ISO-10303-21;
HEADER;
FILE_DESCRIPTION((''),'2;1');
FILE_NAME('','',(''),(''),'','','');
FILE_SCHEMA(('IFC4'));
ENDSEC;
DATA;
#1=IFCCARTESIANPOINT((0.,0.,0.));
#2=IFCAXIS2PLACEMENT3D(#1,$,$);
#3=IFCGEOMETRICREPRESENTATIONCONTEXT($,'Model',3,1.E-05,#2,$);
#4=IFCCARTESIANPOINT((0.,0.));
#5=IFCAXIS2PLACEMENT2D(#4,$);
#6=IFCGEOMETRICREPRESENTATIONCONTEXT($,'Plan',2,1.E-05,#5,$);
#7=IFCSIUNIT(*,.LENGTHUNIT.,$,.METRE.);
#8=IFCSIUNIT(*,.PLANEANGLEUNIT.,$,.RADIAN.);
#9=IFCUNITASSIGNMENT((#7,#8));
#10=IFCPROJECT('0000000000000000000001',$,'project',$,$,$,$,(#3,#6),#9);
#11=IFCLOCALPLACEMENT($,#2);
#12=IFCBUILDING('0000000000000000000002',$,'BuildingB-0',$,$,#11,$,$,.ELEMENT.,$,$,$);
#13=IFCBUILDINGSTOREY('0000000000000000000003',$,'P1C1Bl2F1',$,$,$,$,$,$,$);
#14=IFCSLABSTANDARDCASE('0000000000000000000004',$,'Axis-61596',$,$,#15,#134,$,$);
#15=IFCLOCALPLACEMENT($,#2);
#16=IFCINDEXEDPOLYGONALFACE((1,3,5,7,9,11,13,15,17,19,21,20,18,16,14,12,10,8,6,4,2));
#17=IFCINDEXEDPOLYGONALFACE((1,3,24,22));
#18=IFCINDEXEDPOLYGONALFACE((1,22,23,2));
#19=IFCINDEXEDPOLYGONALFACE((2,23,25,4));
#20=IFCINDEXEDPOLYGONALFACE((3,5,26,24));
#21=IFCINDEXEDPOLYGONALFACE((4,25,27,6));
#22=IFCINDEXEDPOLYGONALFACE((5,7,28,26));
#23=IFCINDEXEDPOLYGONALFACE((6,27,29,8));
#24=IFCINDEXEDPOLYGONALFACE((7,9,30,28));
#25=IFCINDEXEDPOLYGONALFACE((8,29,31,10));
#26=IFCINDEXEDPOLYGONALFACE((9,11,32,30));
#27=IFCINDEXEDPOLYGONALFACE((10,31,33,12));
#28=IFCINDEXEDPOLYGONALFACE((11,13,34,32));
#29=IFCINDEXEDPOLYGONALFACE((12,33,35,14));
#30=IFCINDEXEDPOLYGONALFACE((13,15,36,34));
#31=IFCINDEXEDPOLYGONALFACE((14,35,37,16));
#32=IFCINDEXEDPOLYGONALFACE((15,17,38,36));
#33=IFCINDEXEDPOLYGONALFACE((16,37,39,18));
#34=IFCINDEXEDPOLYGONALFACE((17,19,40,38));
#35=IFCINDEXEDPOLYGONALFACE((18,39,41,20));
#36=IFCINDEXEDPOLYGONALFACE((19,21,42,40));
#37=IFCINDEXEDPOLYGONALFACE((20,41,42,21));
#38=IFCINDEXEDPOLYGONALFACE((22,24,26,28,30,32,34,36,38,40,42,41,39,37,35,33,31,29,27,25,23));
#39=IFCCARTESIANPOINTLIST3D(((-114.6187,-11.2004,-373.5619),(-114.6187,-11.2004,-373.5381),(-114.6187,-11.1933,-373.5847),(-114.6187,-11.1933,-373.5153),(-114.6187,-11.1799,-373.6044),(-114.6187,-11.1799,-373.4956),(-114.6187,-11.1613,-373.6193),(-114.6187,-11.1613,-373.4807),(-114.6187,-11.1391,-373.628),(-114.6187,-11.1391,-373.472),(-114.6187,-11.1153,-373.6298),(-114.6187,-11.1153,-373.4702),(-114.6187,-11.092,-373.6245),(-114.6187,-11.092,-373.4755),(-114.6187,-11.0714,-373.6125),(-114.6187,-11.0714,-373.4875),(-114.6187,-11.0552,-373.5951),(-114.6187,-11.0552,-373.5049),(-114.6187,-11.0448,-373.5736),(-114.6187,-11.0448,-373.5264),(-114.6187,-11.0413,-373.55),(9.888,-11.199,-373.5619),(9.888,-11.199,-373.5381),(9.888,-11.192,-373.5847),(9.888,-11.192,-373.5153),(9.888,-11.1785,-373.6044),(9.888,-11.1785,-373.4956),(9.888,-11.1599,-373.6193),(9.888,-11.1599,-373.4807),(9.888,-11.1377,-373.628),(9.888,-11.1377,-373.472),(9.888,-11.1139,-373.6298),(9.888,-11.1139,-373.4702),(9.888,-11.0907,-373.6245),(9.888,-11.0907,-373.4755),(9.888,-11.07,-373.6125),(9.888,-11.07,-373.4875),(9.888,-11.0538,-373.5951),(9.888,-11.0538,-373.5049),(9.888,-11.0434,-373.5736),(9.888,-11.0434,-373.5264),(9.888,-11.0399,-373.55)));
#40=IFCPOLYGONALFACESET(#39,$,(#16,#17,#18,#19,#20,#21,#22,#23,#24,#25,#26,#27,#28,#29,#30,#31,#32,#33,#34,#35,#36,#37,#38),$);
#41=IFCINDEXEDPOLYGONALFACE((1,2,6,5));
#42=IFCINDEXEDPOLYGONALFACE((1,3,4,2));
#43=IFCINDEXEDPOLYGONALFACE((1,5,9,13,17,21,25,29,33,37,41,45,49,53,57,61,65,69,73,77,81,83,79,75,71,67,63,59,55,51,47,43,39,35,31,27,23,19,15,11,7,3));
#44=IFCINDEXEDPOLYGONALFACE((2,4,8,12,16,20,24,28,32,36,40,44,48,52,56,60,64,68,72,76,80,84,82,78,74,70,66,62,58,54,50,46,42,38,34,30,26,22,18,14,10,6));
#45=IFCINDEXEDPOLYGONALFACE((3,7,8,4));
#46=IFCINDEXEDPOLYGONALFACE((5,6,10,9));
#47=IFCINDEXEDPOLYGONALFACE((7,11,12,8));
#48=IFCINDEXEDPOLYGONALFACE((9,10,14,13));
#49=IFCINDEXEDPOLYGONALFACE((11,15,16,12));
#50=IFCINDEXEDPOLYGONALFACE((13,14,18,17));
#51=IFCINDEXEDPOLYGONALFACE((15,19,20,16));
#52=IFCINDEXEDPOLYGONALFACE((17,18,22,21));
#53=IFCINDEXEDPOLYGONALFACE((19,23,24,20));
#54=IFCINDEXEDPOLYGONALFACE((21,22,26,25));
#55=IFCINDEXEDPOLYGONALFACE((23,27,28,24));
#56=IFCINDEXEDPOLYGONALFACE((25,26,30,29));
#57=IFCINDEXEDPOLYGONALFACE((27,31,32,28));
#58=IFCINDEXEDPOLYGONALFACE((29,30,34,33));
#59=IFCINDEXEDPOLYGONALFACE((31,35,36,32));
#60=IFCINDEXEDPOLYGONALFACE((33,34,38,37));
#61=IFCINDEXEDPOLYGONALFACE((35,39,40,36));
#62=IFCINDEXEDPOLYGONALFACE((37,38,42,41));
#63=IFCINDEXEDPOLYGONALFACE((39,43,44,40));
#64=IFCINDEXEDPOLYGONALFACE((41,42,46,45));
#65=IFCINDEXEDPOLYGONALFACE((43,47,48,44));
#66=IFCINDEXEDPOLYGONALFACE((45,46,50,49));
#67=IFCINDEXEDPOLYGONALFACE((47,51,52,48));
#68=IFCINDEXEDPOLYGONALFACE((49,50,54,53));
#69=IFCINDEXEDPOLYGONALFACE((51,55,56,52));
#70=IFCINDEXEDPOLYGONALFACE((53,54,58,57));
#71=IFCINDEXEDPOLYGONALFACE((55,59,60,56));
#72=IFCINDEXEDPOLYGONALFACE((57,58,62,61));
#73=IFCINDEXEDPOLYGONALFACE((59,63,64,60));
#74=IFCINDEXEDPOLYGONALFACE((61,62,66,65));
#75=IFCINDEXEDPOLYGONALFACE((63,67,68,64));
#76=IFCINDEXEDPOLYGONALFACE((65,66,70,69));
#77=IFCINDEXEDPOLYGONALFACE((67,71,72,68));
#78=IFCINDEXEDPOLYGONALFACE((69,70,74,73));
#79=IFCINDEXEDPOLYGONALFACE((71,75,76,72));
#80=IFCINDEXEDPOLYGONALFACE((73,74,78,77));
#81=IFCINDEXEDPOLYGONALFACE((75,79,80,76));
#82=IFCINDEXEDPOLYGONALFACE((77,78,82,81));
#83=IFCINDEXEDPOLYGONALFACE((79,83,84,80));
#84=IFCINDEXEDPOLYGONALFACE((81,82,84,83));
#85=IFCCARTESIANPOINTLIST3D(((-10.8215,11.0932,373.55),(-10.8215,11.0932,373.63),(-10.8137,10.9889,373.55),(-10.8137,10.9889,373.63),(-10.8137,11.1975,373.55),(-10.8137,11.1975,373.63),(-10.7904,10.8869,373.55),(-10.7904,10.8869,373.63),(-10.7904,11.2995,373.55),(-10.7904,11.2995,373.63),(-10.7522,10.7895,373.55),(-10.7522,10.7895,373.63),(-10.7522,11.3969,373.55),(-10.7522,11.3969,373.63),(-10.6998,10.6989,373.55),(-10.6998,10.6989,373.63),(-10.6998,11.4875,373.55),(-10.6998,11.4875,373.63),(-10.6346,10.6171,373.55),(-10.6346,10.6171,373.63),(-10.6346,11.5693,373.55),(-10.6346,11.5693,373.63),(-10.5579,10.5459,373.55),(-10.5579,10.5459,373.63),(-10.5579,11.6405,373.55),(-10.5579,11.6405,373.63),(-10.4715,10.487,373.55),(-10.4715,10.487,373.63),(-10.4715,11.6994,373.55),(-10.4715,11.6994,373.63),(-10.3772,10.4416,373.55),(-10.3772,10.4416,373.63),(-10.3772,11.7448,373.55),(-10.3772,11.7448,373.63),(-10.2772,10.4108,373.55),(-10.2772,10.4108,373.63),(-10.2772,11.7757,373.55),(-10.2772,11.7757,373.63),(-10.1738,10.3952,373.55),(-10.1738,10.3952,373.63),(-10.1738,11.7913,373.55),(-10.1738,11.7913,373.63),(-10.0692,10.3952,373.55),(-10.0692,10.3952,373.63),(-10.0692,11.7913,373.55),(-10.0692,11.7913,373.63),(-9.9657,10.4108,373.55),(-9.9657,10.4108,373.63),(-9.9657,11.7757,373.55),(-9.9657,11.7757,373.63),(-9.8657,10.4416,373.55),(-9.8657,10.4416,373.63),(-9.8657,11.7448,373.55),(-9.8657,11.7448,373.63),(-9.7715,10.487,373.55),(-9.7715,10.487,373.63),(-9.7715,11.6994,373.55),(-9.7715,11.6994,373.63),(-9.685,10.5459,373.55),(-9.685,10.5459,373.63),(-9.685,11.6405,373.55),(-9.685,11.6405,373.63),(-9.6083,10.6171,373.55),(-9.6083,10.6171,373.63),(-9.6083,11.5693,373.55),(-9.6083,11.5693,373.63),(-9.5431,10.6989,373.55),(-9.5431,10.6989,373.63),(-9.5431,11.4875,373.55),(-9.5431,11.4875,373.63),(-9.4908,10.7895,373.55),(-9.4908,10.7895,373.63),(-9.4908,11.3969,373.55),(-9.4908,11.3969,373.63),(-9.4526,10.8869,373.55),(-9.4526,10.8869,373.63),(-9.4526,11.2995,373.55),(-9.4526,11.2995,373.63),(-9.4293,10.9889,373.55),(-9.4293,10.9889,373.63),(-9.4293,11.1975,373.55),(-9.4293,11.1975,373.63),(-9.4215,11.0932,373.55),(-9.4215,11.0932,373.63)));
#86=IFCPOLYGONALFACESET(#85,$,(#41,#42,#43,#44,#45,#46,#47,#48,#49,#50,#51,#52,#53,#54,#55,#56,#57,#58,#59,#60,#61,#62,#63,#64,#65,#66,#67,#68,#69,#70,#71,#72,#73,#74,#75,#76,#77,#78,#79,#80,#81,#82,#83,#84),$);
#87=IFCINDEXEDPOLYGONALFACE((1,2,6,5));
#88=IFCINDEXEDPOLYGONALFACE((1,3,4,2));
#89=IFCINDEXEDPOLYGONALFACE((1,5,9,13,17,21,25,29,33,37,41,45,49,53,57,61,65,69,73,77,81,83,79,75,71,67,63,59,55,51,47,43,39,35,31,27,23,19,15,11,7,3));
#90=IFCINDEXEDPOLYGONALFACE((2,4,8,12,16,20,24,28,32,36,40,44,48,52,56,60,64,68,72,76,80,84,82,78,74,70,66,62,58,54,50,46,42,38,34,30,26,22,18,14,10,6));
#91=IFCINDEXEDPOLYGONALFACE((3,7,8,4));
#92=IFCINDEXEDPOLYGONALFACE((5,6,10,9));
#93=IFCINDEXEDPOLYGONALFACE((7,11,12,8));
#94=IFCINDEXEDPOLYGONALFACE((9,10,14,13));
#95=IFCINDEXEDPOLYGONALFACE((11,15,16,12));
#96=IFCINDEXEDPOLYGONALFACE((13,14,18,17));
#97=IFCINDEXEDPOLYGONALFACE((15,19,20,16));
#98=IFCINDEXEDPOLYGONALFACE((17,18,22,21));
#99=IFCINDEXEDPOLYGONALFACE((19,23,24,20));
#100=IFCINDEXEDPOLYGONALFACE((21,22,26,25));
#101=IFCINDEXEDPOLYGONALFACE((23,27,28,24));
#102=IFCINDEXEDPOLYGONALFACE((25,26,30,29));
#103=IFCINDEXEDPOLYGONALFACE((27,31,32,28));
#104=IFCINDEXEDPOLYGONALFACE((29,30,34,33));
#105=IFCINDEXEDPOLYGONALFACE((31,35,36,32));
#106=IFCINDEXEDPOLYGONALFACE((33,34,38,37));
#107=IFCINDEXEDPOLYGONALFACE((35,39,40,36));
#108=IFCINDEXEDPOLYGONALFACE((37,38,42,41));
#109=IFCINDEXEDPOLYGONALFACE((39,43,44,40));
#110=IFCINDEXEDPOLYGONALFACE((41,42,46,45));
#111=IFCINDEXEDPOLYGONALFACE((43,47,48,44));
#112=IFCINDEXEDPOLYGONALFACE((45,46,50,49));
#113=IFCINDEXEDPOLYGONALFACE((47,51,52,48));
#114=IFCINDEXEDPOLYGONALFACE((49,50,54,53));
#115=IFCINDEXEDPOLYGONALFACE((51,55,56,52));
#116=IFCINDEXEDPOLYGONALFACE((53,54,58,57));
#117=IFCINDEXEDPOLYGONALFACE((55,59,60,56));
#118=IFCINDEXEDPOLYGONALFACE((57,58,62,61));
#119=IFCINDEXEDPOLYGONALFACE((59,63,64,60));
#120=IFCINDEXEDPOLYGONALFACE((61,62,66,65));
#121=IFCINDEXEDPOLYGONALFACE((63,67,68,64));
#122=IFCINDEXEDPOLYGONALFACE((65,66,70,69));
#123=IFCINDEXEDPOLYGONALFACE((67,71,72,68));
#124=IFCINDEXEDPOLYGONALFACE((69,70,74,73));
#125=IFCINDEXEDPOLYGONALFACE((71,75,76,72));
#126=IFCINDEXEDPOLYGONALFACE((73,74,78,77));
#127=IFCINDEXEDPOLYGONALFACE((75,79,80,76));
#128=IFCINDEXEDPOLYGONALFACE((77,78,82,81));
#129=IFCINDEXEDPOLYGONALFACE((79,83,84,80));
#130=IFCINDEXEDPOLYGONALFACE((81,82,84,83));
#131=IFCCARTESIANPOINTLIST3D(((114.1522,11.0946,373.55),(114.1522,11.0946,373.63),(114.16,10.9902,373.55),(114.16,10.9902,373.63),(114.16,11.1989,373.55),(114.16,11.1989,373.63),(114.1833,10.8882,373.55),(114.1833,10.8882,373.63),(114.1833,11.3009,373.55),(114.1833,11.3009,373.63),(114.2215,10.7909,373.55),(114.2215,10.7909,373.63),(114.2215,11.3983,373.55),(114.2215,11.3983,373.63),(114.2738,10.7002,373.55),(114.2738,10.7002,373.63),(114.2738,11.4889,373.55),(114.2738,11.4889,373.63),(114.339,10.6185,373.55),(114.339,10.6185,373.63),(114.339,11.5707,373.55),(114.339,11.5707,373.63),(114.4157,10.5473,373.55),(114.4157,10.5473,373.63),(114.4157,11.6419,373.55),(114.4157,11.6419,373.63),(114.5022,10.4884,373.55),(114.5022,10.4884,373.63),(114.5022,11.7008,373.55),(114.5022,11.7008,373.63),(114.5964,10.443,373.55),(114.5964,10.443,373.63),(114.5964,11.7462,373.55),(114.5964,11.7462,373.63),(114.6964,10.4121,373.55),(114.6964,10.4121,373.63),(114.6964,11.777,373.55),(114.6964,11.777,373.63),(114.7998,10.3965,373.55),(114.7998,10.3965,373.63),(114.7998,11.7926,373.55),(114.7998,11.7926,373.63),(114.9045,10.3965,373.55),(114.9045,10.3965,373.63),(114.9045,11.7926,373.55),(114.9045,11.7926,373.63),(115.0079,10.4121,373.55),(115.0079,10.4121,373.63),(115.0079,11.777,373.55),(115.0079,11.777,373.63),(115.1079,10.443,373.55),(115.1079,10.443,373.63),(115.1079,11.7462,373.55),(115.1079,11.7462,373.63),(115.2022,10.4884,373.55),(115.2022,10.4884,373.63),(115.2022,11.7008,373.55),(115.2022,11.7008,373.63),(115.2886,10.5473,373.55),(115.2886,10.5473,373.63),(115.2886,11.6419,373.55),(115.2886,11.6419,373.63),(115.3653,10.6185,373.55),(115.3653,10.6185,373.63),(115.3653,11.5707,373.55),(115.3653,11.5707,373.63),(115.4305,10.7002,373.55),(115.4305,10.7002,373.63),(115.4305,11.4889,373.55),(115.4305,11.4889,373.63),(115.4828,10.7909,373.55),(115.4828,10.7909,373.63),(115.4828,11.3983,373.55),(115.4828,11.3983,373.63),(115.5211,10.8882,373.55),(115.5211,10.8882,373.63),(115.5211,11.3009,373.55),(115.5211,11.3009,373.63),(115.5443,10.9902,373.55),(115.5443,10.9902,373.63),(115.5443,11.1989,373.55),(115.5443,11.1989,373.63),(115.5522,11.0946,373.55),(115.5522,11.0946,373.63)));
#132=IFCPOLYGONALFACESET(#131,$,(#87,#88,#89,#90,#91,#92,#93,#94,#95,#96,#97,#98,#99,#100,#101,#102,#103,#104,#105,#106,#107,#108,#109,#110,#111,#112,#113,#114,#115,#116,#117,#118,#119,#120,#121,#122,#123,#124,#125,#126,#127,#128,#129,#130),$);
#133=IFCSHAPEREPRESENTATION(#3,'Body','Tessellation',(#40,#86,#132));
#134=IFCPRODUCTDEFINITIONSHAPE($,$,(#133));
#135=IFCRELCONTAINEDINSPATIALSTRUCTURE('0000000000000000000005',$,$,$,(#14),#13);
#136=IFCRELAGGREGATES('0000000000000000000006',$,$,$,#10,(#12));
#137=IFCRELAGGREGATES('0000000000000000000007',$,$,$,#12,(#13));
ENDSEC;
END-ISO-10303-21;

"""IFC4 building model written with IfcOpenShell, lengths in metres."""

from ifc_helpers import new_model, entity, si_unit, frame, origin, origin_2d, place, context, project, spatial, circle, extrude, element, save


model = new_model("IFC4")

# Units and contexts
model_context = context("Model", 3, precision=1e-05, world=origin())
plan_context = context("Plan", 2, precision=1e-05, world=origin_2d())
ifc_project = project(units=[si_unit("LENGTHUNIT", "METRE"), si_unit("PLANEANGLEUNIT", "RADIAN")], contexts=[model_context, plan_context])

# Building, storey
building_placement = place(None, origin())
building = spatial("IfcBuilding", under=ifc_project, at=building_placement, Name="BuildingB-0", CompositionType="ELEMENT")
storey = spatial("IfcBuildingStorey", under=building, Name="P1C1Bl2F1")

# Slab
element("IfcSlabStandardCase", 1, inside=storey, Name="Axis-61596", context=model_context, shape_type="AdvancedSweptSolid", body=[
    entity("IfcSurfaceCurveSweptAreaSolid", entity("IfcCircleProfileDef", "AREA", None, None, 0.08), None, entity("IfcPolyline", [entity("IfcCartesianPoint", [-9.888, 11.1199, 373.55]), entity("IfcCartesianPoint", [114.6187, 11.1213, 373.55])]), None, None, entity("IfcPlane", entity("IfcAxis2Placement3D", entity("IfcCartesianPoint", [-9.888, 11.1199, 373.55]), entity("IfcDirection", [0.0, 0.0, 1.0]), entity("IfcDirection", [1.0, 0.0, 0.0])))),
    extrude(circle(Radius=0.7), frame((-10.1215, 11.0932, 373.55)), (0.0, 0.0, 1.0), 0.08),
    extrude(circle(Radius=0.7), frame((114.8522, 11.0946, 373.55)), (0.0, 0.0, 1.0), 0.08),
])

save(model, "model.ifc")
